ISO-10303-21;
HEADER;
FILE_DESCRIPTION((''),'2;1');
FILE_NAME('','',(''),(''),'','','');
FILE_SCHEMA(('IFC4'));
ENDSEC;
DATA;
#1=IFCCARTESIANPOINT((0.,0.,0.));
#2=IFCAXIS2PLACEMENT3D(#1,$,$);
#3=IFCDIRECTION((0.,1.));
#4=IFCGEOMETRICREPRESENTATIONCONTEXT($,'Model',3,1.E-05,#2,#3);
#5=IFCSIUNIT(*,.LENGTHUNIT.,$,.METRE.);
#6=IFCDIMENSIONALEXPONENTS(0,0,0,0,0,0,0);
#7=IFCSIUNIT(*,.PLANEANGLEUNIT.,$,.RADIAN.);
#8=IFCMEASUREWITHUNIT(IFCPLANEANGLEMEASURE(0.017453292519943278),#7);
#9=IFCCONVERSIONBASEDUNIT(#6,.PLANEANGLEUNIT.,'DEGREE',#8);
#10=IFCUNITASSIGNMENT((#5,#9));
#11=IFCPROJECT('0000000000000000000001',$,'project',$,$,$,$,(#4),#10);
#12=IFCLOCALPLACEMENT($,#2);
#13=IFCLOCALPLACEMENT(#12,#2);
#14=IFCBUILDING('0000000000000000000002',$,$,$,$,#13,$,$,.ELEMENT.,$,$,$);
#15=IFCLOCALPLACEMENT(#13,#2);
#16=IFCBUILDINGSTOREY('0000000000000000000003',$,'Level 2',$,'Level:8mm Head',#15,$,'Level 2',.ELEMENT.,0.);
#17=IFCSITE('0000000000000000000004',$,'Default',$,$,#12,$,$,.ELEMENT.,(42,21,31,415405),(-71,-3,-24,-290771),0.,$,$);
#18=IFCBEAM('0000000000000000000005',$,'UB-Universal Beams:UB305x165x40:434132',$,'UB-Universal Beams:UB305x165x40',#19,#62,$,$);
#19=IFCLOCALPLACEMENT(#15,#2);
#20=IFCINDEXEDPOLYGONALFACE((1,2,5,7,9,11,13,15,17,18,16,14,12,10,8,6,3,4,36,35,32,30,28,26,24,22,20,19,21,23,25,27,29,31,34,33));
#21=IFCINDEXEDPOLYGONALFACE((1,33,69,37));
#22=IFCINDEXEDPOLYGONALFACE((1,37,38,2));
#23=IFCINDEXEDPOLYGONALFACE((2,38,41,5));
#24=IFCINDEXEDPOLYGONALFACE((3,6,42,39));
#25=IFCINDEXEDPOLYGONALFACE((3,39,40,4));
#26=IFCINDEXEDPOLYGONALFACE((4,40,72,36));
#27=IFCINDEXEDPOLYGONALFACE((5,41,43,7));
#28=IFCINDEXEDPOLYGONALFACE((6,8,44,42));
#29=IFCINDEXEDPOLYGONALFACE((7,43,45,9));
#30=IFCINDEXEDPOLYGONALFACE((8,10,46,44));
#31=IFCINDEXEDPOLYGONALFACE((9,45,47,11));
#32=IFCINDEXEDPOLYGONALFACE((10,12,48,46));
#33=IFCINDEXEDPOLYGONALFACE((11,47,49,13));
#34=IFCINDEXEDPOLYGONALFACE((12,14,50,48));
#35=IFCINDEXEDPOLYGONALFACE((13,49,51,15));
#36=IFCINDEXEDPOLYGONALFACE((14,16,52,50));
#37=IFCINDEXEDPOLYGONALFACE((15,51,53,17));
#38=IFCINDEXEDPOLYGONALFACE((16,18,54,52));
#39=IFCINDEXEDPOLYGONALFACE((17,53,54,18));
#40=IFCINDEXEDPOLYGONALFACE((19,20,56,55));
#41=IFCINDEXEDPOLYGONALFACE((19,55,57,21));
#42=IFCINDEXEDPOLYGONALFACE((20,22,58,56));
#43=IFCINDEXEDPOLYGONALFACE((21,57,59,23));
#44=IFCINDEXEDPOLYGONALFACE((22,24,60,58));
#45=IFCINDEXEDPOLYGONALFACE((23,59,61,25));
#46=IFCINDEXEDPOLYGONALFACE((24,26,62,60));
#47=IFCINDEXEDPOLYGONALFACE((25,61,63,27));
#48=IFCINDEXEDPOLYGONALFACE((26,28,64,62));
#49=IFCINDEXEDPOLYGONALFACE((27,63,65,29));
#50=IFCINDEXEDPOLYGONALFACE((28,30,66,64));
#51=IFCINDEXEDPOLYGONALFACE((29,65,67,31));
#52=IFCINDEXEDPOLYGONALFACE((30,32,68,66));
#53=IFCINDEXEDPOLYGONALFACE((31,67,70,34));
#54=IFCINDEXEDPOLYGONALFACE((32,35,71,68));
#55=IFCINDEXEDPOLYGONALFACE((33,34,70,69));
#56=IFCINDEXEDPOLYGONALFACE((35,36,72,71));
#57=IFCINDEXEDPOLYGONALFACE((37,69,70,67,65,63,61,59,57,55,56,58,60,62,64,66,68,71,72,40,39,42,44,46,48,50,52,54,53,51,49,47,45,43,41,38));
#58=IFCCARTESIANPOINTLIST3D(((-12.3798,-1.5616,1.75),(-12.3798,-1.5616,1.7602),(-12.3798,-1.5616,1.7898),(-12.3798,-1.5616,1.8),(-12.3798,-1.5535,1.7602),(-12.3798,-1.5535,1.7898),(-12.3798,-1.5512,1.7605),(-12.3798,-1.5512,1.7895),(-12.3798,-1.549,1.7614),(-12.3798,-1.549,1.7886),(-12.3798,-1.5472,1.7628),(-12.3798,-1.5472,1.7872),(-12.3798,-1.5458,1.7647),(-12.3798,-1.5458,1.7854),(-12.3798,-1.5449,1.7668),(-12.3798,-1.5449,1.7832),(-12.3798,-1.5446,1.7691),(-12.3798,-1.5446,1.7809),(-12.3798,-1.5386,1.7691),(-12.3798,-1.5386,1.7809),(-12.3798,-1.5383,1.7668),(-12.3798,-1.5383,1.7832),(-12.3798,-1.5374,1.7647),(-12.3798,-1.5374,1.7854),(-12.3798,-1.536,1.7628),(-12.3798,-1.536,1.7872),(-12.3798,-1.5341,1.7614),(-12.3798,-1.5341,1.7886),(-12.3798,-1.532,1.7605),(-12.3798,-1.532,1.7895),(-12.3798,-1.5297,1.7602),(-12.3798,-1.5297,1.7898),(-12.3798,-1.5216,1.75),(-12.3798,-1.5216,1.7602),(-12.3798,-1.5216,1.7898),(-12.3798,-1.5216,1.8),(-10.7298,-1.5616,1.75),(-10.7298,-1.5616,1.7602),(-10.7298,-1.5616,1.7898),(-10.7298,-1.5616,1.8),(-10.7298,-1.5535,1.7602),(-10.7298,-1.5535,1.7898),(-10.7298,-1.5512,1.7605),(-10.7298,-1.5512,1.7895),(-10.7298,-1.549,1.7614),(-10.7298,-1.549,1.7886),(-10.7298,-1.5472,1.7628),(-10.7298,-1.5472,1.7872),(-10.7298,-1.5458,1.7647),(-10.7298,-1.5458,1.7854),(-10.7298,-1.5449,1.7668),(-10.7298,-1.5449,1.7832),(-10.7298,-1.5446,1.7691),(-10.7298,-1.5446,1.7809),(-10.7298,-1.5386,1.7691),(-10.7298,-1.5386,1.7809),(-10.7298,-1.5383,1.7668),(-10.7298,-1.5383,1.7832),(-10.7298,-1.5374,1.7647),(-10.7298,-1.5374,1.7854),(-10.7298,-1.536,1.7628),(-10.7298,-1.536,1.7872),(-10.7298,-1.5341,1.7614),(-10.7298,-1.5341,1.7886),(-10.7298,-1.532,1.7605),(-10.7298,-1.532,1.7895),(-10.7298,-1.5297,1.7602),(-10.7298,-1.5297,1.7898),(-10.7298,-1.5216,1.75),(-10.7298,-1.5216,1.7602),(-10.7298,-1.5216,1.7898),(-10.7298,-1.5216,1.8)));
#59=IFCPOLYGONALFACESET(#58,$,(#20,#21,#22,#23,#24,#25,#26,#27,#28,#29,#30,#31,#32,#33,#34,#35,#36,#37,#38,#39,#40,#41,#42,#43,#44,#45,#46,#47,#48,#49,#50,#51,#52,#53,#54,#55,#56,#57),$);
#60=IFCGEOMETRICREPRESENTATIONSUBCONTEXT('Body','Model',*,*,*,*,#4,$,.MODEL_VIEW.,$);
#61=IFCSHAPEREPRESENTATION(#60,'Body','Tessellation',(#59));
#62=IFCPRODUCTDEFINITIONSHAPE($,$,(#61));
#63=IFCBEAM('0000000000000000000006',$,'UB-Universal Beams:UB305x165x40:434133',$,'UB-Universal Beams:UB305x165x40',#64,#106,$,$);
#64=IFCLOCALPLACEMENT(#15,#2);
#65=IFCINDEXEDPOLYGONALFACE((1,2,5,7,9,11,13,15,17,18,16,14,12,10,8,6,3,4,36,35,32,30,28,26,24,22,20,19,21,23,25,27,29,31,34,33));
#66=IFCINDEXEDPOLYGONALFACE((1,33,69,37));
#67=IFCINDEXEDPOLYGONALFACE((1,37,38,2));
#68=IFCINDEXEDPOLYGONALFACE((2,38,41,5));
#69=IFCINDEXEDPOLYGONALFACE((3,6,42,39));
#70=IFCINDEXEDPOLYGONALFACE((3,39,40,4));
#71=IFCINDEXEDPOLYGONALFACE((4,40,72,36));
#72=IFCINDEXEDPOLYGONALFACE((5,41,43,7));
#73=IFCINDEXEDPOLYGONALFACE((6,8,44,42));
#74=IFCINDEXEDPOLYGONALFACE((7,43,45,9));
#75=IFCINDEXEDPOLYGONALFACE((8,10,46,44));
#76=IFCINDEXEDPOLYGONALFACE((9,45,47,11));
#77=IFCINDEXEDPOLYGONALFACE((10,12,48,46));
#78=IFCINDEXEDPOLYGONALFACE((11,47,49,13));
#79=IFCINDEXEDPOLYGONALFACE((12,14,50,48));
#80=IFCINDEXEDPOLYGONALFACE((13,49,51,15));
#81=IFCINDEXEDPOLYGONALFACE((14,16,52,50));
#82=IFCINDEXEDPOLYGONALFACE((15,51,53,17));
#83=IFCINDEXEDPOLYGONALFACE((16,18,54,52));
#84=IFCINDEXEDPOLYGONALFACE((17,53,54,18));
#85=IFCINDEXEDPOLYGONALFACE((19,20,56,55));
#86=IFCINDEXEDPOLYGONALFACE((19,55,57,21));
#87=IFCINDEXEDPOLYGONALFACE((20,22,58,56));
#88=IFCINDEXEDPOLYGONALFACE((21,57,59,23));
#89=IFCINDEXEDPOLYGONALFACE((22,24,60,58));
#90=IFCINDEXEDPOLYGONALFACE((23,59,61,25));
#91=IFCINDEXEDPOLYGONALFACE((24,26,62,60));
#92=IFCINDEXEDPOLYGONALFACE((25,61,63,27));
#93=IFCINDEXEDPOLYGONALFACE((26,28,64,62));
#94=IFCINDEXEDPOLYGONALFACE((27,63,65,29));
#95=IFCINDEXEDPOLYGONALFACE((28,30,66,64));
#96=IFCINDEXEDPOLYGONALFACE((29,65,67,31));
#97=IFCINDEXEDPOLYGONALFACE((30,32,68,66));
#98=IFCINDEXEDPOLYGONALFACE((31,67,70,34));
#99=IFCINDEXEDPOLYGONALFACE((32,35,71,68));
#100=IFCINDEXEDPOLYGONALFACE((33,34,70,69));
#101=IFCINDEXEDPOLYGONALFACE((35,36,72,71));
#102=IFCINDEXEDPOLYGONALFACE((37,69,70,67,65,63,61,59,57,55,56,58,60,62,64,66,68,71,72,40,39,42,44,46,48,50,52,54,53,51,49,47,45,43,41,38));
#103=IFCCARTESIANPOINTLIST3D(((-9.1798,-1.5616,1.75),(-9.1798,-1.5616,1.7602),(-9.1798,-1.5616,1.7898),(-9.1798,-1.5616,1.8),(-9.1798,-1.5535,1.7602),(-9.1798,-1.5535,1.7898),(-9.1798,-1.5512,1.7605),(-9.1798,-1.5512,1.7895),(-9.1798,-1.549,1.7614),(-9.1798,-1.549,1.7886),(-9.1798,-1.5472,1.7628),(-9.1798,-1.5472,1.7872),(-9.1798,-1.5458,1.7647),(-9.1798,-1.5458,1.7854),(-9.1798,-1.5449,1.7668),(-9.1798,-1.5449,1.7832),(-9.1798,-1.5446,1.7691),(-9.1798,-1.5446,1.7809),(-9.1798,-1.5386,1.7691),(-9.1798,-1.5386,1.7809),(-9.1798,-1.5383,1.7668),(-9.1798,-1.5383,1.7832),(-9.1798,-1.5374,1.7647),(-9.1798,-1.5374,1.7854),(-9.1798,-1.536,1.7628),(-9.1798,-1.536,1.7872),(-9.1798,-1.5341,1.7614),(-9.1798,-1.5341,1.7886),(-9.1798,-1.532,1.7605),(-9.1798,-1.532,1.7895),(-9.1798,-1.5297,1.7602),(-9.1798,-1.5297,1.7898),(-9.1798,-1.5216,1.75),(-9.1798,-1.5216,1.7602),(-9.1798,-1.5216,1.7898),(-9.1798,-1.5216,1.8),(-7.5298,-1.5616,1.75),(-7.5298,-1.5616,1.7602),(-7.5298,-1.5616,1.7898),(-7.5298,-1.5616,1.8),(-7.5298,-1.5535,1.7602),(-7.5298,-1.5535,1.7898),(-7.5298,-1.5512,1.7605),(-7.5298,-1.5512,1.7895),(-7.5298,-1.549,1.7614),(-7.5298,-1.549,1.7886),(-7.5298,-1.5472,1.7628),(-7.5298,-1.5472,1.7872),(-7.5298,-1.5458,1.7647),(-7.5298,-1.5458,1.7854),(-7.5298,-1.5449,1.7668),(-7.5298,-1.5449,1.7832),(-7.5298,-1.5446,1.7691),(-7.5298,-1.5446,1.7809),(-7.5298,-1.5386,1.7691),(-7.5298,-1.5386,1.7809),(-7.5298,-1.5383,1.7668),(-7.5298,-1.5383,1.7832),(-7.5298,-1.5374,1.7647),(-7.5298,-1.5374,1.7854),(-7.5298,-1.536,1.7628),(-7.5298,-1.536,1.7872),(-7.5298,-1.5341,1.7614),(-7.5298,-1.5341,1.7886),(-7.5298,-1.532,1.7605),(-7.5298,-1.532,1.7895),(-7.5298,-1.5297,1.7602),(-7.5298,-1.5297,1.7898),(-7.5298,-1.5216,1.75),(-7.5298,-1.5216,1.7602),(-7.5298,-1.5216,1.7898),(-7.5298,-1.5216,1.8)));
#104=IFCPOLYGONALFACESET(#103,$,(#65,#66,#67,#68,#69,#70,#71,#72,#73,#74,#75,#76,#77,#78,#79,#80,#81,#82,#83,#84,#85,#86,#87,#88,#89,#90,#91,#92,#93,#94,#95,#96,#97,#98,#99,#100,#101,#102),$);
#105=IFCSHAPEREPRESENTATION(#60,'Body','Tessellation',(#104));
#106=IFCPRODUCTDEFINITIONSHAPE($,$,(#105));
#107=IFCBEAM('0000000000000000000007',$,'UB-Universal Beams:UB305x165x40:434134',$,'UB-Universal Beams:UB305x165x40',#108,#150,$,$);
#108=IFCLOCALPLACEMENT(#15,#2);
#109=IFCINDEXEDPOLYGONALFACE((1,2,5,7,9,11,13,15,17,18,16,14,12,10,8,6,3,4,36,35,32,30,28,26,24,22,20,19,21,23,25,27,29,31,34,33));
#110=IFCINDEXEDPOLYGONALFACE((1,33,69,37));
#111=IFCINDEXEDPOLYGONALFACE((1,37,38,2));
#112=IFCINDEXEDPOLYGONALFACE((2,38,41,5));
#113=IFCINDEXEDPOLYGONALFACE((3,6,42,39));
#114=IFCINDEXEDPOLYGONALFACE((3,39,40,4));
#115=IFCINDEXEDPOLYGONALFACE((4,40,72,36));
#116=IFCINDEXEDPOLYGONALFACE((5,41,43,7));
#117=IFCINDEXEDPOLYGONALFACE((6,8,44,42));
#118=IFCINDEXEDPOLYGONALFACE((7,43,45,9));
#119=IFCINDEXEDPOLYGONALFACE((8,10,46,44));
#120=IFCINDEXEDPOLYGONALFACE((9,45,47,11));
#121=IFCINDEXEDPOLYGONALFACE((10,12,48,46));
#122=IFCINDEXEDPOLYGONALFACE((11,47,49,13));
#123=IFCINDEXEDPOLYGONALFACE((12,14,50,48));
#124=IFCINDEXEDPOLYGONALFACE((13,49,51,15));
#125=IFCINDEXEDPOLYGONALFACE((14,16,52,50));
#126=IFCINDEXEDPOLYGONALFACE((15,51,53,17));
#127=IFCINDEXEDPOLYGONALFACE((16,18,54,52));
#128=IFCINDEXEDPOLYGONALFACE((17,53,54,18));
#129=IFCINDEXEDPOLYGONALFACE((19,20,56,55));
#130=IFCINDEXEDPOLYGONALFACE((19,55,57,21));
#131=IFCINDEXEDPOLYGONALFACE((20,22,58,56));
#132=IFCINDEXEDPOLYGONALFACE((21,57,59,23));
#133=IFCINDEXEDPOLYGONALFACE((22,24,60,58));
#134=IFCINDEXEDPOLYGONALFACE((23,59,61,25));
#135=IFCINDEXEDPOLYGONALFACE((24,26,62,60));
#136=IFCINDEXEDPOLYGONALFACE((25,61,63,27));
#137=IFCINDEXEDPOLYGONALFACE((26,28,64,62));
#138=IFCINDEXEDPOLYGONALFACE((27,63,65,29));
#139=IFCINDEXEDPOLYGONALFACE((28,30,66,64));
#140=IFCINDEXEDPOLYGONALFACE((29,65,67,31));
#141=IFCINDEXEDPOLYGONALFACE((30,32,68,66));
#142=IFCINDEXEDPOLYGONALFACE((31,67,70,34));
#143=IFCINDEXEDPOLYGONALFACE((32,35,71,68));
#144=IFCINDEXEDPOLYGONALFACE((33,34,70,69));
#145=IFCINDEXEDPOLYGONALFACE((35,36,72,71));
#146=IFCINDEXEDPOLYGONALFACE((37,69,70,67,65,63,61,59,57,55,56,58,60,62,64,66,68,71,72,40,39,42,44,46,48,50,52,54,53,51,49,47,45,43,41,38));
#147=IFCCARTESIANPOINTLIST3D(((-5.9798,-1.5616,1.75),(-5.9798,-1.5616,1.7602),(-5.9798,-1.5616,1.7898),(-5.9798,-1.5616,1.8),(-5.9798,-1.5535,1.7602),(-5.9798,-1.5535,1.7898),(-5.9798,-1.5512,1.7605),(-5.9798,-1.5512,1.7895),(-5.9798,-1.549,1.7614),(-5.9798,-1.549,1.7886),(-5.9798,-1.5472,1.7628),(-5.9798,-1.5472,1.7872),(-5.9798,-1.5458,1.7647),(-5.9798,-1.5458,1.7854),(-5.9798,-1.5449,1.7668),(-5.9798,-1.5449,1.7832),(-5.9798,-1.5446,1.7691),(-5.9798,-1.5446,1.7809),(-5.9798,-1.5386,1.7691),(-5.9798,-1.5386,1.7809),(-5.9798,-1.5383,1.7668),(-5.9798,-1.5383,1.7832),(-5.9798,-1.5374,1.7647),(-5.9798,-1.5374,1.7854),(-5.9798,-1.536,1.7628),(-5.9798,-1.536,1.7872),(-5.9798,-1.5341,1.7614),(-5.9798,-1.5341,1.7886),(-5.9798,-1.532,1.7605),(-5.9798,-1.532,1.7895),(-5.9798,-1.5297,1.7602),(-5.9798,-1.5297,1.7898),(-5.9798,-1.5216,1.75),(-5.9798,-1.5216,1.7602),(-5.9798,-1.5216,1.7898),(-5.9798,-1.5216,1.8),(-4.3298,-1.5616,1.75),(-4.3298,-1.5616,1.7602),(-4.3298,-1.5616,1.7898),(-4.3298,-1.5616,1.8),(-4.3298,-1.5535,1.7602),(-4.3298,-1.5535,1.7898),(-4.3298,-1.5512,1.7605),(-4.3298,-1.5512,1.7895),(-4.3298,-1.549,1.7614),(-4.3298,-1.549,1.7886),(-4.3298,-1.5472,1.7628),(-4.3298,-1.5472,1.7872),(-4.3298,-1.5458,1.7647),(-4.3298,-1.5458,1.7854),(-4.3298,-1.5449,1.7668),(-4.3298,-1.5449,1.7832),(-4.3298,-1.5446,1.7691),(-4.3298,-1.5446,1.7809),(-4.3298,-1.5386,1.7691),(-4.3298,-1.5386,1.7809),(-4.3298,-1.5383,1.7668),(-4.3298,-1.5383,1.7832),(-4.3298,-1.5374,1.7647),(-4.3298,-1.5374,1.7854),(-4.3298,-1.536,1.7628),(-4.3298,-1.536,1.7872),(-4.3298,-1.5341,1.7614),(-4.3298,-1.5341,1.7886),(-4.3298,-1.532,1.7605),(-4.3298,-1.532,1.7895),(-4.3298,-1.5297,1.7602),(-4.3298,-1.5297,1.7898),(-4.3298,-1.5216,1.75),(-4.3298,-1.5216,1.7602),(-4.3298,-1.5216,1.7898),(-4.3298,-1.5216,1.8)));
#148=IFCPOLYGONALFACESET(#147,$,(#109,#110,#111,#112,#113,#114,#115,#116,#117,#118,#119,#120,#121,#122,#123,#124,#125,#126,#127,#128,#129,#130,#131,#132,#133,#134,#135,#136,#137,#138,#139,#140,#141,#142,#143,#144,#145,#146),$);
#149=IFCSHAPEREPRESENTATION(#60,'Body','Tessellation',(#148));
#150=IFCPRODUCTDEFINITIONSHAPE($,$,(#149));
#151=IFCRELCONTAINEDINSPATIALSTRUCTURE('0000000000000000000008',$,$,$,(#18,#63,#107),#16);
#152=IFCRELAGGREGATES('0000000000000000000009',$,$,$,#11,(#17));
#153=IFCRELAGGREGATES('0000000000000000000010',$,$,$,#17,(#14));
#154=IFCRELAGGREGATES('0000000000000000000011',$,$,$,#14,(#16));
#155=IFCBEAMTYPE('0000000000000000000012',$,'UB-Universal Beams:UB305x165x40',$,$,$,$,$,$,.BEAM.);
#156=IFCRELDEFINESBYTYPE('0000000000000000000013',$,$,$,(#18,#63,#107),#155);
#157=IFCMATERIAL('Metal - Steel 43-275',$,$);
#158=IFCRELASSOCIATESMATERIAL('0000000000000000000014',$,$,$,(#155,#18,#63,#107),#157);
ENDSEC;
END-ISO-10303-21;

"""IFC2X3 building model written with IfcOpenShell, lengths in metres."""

from ifc_helpers import new_model, entity, si_unit, converted_unit, direction, frame, frame_2d, origin, place, context, subcontext, project, spatial, i_section, extrude, material, type_object, element, save


model = new_model("IFC2X3")

# Units and contexts
model_context = context("Model", 3, precision=1e-05, world=origin(), true_north=direction((0.0, 1.0)))
body_context = subcontext(model_context, "Body", "Model", "MODEL_VIEW")
ifc_project = project(units=[si_unit("LENGTHUNIT", "METRE"), converted_unit("PLANEANGLEUNIT", "DEGREE", entity("IfcPlaneAngleMeasure", 0.017453292519943278), si_unit("PLANEANGLEUNIT", "RADIAN"), dimensions=[0, 0, 0, 0, 0, 0, 0])], contexts=[model_context])

# Site, building, storey
site_placement = place(None, origin())
site = spatial("IfcSite", under=ifc_project, at=site_placement, Name="Default", CompositionType="ELEMENT", RefLatitude=(42, 21, 31, 415405), RefLongitude=(-71, -3, -24, -290771), RefElevation=0.0)
building_placement = place(site_placement, origin())
building = spatial("IfcBuilding", under=site, at=building_placement, CompositionType="ELEMENT")
storey_placement = place(building_placement, origin())
storey = spatial("IfcBuildingStorey", under=building, at=storey_placement, Name="Level 2", ObjectType="Level:8mm Head", LongName="Level 2", CompositionType="ELEMENT", Elevation=0.0)

# Shared definitions
ifc_material = material(Name="Metal - Steel 43-275")

# Beams
beam_type = type_object("IfcBeamType", Name="UB-Universal Beams:UB305x165x40", PredefinedType="BEAM", material=ifc_material)
for number, where, name in (
    (1, (-12.3798, -1.5416, 1.8), "UB-Universal Beams:UB305x165x40:434132"),
):
    element("IfcBeam", number, at=place(storey_placement, frame(where)), inside=storey, type_object=beam_type, material=ifc_material, Name=name, ObjectType="UB-Universal Beams:UB305x165x40", context=body_context, shape_type="SweptSolid", body=[
        extrude(i_section(OverallWidth=0.04, OverallDepth=0.05, WebThickness=0.006, FlangeThickness=0.0102, FilletRadius=0.0089, at=frame_2d((0.0, 0.0), x_axis=(0.0, 1.0))), frame((0.0, 0.0, -0.025), z_axis=(1.0, 0.0, 0.0), x_axis=(0.0, 0.0, -1.0)), (0.0, 0.0, 1.0), 1.65),
    ])
for number, where, name in (
    (2, (-9.1798, -1.5416, 1.8), "UB-Universal Beams:UB305x165x40:434133"),
    (3, (-5.9798, -1.5416, 1.8), "UB-Universal Beams:UB305x165x40:434134"),
):
    element("IfcBeam", number, at=place(storey_placement, frame(where)), inside=storey, type_object=beam_type, material=ifc_material, Name=name, ObjectType="UB-Universal Beams:UB305x165x40", context=body_context, shape_type="SweptSolid", body=[
        extrude(i_section(OverallWidth=0.04, OverallDepth=0.05, WebThickness=0.006, FlangeThickness=0.0102, FilletRadius=0.0089, at=frame_2d((0.0, 0.0), x_axis=(0.0, 1.0))), frame((0.0, 0.0, -0.025), z_axis=(1.0, 0.0, 0.0), x_axis=(0.0, 0.0, -1.0)), (0.0, 0.0, 1.0), 1.65),
    ])

save(model, "model.ifc")
